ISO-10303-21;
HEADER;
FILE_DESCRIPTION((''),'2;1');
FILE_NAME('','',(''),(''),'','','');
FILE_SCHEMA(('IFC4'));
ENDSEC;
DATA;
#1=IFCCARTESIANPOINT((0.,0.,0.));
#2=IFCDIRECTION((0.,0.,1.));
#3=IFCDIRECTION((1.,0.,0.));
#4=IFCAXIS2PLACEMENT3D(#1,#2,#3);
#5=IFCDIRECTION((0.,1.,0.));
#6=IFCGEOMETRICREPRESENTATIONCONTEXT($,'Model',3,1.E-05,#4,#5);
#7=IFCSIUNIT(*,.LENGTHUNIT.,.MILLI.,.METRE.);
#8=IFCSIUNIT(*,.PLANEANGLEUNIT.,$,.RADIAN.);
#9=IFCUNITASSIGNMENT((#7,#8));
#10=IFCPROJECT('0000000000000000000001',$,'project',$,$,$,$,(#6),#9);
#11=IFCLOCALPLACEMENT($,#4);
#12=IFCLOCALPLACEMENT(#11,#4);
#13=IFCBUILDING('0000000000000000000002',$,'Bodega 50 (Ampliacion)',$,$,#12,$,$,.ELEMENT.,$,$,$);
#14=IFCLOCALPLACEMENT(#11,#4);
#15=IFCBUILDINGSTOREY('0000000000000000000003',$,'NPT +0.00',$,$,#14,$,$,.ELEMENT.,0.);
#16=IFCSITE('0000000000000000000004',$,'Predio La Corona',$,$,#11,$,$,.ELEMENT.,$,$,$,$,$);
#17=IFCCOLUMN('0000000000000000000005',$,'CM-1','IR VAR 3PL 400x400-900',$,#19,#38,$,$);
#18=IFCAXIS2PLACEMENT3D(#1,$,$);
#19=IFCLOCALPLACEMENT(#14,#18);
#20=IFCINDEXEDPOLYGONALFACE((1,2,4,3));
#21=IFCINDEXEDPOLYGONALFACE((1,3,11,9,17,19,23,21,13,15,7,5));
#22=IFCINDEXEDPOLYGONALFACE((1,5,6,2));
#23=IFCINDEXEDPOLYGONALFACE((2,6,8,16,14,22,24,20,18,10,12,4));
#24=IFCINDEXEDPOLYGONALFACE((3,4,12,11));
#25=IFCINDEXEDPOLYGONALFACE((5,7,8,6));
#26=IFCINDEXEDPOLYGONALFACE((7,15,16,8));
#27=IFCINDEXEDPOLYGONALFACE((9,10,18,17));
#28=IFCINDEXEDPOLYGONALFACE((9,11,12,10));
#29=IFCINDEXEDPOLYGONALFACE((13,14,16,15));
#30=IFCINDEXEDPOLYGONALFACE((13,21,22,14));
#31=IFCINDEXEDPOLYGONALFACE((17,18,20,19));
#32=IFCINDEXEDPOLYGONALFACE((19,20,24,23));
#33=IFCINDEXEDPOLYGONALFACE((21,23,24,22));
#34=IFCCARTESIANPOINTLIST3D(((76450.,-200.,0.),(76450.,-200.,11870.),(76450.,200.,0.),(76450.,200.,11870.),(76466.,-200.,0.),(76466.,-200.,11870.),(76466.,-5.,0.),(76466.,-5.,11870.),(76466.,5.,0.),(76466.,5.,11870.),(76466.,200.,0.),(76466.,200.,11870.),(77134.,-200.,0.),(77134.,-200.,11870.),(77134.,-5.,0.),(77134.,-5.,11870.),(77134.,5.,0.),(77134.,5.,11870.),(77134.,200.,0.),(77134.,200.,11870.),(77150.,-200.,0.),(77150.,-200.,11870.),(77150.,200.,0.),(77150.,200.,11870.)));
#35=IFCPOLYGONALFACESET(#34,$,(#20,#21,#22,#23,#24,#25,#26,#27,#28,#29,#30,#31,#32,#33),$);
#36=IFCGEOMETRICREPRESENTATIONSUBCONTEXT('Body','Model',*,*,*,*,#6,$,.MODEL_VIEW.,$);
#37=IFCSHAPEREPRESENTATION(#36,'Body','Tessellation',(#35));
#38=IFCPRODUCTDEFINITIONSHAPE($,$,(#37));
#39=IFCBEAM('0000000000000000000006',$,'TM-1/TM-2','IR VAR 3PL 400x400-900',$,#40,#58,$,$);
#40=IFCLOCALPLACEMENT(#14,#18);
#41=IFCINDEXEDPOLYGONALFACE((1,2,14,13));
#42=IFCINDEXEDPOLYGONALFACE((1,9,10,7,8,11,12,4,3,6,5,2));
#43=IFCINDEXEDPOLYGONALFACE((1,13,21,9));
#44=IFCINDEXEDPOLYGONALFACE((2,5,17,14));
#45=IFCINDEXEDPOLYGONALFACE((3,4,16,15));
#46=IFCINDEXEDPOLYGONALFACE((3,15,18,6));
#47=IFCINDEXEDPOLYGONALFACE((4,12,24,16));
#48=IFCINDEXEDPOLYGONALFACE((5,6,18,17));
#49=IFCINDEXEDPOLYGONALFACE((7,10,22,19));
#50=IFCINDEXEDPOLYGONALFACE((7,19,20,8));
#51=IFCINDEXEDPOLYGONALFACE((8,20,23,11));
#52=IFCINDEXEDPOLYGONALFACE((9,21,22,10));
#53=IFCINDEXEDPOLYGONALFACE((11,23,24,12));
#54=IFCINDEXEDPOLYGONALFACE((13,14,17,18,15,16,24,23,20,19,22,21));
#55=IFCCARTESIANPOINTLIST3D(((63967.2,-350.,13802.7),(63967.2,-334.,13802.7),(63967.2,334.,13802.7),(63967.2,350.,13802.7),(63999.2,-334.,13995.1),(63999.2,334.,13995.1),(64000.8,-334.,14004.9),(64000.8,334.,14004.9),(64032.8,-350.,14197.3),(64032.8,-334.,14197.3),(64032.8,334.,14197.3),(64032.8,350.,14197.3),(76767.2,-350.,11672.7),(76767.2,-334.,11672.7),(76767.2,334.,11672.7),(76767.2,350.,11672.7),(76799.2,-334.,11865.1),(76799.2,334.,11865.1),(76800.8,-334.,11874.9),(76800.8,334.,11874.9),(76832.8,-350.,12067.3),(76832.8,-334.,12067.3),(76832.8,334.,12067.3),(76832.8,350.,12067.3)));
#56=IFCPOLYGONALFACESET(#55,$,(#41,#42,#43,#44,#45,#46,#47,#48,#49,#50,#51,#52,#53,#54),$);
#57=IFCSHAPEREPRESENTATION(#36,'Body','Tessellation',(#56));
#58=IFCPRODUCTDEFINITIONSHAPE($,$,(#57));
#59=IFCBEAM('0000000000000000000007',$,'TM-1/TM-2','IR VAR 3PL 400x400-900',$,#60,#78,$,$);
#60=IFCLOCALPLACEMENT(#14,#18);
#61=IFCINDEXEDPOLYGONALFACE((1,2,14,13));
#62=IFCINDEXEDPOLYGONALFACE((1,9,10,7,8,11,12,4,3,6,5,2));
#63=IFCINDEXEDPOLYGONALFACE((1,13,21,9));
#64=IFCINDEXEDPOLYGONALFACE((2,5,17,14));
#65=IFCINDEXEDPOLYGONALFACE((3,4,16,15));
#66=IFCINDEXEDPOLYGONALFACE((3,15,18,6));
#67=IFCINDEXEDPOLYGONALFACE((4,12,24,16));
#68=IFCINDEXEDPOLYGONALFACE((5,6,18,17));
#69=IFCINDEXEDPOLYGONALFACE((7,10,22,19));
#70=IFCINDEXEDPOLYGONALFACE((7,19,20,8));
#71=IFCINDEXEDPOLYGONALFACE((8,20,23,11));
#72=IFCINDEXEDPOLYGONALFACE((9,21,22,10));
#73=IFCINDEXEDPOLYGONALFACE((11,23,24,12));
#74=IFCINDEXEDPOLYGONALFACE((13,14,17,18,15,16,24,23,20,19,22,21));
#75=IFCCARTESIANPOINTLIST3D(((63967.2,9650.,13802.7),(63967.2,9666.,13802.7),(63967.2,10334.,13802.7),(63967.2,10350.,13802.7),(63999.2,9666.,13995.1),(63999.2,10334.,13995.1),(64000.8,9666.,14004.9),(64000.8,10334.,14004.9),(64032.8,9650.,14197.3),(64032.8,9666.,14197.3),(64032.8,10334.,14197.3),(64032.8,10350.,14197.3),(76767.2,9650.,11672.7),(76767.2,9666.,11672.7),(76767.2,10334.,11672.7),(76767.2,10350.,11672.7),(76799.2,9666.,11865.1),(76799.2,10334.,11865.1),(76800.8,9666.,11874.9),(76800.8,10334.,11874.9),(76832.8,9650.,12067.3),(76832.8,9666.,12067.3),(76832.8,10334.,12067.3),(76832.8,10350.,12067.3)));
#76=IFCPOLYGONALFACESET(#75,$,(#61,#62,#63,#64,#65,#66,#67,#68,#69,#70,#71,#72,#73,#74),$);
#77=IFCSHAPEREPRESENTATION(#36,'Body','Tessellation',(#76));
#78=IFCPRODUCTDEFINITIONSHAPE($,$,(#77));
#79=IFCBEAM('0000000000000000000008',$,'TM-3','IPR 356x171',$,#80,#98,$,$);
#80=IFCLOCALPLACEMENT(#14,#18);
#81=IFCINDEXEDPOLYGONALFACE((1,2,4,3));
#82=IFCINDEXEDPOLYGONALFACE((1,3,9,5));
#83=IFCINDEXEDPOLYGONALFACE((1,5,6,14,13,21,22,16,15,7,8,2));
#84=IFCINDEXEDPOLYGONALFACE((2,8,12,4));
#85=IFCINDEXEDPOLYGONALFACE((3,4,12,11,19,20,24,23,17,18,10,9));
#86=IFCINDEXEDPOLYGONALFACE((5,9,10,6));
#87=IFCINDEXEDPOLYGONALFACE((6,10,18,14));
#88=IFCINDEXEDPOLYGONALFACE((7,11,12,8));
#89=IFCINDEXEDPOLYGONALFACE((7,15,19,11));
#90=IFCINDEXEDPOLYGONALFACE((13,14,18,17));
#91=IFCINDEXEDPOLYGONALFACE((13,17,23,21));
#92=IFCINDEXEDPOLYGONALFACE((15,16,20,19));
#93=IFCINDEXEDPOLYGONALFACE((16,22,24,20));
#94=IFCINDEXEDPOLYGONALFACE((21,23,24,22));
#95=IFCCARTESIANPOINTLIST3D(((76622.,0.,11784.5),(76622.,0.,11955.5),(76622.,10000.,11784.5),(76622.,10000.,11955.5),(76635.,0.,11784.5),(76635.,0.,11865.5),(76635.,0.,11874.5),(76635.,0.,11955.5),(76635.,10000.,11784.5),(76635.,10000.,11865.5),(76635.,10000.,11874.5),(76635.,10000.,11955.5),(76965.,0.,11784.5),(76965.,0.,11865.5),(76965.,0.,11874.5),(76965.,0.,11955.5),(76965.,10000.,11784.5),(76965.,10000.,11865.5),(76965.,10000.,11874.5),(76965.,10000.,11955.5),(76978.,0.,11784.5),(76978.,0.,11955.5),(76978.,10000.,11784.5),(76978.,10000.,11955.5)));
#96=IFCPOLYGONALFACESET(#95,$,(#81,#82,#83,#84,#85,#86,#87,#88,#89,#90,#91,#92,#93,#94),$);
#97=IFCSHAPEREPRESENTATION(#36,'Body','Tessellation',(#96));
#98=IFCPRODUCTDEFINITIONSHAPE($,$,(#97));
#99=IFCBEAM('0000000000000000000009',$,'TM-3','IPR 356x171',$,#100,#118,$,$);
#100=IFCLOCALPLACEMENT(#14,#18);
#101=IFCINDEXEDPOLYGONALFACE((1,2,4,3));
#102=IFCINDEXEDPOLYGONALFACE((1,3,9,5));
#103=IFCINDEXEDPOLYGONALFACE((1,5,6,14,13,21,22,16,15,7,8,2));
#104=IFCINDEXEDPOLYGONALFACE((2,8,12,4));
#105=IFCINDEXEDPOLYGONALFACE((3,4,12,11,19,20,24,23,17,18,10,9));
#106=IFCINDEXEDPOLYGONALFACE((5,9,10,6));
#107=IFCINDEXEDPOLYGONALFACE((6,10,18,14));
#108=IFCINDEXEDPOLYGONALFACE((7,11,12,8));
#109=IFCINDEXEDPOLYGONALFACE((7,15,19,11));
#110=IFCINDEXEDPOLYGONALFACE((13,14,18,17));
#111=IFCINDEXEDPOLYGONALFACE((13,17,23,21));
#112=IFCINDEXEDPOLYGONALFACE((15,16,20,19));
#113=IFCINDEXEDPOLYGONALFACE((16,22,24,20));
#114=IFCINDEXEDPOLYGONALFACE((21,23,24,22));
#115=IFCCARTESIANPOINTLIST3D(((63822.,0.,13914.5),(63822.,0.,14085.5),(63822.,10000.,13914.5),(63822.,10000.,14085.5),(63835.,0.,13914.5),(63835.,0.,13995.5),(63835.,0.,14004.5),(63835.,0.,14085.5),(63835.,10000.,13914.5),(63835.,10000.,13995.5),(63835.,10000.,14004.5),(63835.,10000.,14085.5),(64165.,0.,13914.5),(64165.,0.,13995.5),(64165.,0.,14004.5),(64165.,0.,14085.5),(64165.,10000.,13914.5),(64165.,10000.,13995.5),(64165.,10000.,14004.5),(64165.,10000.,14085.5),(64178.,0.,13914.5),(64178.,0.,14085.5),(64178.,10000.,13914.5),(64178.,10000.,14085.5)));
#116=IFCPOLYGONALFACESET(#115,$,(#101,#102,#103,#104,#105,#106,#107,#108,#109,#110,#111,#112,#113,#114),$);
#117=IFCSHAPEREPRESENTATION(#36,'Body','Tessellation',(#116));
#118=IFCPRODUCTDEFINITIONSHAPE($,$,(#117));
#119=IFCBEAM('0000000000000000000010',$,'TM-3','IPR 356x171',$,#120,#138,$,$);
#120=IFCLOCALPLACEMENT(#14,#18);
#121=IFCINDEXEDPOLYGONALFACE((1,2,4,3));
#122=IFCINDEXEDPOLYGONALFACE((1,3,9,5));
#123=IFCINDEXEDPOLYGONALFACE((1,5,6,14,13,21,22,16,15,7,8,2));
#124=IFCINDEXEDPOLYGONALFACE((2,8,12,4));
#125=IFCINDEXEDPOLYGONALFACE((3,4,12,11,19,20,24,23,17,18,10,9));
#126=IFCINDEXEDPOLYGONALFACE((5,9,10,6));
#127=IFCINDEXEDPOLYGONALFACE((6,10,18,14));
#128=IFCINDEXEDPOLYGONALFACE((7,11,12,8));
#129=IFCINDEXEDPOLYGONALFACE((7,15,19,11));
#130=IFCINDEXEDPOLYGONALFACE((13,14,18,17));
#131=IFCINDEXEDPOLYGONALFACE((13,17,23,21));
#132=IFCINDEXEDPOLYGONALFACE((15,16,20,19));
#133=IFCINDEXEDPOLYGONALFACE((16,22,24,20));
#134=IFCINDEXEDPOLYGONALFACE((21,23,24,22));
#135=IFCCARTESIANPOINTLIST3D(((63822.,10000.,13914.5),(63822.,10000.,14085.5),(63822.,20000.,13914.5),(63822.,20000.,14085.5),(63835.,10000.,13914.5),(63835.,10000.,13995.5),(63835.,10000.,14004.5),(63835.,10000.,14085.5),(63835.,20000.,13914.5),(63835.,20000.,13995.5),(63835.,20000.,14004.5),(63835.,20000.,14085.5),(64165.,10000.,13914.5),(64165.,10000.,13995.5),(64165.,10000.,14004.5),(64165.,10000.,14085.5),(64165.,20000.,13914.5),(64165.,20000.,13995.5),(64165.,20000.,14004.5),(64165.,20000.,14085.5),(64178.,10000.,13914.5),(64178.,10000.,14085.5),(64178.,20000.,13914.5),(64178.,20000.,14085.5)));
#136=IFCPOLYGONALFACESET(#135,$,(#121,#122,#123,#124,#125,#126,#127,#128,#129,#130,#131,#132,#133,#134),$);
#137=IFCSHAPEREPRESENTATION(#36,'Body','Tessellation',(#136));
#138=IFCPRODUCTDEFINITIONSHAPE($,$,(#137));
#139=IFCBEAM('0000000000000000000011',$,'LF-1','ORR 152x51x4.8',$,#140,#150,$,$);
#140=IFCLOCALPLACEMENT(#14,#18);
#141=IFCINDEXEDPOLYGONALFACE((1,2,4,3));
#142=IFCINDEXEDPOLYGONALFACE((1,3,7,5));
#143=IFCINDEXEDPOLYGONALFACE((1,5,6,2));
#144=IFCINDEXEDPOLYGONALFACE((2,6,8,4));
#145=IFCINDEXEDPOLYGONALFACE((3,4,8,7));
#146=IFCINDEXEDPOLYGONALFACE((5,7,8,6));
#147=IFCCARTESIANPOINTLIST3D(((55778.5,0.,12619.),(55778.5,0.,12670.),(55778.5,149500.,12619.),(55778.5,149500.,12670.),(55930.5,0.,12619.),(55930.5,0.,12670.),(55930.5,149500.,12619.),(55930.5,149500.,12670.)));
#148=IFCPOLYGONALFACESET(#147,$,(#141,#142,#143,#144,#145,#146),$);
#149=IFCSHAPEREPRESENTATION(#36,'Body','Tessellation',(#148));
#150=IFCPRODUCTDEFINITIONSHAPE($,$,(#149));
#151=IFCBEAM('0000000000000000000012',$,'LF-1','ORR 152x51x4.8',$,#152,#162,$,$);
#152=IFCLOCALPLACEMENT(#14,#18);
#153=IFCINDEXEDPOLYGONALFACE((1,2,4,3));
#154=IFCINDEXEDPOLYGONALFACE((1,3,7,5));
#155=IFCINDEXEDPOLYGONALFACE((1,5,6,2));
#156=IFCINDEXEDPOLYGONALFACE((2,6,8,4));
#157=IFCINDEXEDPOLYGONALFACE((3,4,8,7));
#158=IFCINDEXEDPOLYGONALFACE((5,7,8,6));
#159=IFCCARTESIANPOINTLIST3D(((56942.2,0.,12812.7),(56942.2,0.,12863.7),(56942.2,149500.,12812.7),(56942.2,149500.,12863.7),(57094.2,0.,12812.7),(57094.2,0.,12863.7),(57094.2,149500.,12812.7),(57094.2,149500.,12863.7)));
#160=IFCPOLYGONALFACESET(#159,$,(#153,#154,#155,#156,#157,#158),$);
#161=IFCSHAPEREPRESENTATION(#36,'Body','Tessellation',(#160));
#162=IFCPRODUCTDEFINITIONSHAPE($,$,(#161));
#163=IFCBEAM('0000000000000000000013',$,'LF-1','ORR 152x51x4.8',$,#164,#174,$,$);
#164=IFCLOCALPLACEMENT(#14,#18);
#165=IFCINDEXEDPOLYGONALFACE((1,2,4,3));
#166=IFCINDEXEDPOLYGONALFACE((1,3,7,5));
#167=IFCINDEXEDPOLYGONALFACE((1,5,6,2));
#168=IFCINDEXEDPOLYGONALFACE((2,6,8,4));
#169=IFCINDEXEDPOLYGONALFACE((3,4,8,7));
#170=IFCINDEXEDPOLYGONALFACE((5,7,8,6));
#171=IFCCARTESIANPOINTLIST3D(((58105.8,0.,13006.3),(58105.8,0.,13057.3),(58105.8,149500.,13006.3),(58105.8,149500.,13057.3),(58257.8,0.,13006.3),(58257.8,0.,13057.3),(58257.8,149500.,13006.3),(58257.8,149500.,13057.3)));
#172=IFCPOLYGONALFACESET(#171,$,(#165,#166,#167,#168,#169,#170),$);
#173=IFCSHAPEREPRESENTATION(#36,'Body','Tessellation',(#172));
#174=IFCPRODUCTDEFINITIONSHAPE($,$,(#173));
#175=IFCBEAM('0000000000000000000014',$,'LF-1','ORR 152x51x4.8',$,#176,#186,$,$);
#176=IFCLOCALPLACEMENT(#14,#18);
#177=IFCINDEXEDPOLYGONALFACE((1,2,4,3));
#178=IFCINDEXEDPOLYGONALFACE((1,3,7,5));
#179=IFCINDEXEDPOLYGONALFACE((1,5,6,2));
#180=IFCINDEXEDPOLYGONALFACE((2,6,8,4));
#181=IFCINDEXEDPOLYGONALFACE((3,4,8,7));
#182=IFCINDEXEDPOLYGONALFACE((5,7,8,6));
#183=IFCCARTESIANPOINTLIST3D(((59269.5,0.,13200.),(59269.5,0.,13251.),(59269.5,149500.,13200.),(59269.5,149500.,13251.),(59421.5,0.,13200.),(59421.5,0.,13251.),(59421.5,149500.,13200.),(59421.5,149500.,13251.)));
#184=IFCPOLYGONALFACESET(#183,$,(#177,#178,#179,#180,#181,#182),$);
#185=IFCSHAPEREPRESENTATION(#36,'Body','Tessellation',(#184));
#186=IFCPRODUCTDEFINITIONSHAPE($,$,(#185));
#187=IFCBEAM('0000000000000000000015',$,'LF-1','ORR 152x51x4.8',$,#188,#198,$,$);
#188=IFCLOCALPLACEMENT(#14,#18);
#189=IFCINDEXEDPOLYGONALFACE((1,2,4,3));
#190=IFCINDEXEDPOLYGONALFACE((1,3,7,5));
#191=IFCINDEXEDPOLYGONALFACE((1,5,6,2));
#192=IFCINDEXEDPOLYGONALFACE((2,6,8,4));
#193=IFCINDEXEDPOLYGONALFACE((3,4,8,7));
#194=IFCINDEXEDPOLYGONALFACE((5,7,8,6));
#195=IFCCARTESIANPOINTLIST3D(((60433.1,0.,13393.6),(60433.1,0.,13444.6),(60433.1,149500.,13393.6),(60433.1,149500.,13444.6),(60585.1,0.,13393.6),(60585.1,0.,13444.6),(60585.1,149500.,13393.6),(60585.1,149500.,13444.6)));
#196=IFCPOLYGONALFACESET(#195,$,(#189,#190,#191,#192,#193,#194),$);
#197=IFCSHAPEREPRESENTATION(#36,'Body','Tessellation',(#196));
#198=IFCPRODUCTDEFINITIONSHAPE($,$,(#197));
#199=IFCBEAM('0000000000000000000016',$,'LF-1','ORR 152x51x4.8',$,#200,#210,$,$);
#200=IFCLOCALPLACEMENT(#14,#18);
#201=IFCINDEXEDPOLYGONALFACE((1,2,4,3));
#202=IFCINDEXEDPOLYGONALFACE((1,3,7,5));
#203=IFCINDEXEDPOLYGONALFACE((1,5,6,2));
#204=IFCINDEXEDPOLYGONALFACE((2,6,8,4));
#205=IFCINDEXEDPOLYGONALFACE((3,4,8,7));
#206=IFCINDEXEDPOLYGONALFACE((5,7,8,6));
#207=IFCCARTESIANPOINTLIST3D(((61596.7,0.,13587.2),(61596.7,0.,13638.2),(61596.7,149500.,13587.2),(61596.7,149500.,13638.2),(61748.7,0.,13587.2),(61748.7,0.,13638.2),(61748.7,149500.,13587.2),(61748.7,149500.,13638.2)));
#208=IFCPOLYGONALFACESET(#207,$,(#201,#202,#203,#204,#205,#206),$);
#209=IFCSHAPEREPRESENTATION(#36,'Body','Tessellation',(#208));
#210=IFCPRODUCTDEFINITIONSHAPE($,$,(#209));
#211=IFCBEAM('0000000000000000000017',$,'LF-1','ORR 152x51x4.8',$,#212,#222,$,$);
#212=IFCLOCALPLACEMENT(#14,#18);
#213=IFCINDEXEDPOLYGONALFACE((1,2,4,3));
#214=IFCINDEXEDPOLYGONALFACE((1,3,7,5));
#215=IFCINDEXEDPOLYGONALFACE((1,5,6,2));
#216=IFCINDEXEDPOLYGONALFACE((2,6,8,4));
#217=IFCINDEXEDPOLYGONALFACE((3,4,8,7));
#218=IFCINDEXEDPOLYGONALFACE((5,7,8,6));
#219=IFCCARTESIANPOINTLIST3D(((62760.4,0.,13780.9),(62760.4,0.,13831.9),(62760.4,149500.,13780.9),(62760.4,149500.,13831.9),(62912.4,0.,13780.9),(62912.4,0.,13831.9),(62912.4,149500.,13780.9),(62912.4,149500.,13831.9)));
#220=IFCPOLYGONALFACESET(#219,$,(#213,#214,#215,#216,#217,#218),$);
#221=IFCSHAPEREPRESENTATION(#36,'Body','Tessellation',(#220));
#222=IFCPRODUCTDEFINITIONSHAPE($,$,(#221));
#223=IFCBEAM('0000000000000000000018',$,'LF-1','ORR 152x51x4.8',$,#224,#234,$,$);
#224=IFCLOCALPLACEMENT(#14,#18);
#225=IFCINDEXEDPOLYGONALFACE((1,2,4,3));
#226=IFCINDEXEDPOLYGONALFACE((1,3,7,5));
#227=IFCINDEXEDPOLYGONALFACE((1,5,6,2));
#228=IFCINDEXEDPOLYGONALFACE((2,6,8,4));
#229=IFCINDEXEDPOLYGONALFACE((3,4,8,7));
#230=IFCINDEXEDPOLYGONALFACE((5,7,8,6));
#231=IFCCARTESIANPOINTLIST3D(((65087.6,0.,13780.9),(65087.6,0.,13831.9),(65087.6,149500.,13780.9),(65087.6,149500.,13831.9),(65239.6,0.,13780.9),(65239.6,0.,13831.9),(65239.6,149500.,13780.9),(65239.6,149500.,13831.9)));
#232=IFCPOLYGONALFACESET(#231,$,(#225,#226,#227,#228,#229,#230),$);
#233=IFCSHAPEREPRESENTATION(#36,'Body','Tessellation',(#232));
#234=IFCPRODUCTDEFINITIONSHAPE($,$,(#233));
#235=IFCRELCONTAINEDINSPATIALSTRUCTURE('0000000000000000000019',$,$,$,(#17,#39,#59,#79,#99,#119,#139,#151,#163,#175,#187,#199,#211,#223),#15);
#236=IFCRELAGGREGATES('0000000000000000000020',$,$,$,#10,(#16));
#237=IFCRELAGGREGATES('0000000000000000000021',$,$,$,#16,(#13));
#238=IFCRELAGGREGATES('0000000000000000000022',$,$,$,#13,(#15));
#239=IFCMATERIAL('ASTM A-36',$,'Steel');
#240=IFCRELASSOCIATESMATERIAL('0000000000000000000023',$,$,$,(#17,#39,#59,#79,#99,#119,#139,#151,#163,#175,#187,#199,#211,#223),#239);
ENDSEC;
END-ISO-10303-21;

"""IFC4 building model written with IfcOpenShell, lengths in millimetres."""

from ifc_helpers import new_model, si_unit, direction, frame, origin_with_axes, origin_2d, place, context, subcontext, project, spatial, rectangle, i_section, extrude, material, element, save


model = new_model("IFC4")

# Units and contexts
model_context = context("Model", 3, precision=1e-05, world=origin_with_axes(), true_north=direction((0.0, 1.0, 0.0)))
body_context = subcontext(model_context, "Body", "Model", "MODEL_VIEW")
ifc_project = project(units=[si_unit("LENGTHUNIT", "METRE", prefix="MILLI"), si_unit("PLANEANGLEUNIT", "RADIAN")], contexts=[model_context])

# Site, building, storey
site_placement = place(None, origin_with_axes())
site = spatial("IfcSite", under=ifc_project, at=site_placement, Name="Predio La Corona", CompositionType="ELEMENT")
building_placement = place(site_placement, origin_with_axes())
building = spatial("IfcBuilding", under=site, at=building_placement, Name="Bodega 50 (Ampliacion)", CompositionType="ELEMENT")
storey_placement = place(site_placement, origin_with_axes())
storey = spatial("IfcBuildingStorey", under=building, at=storey_placement, Name="NPT +0.00", CompositionType="ELEMENT", Elevation=0.0)

# Column
ifc_material = material(Name="ASTM A-36", Category="Steel")
column_placement = place(storey_placement, frame((76800.0, 0.0, 0.0), z_axis=(0.0, 0.0, 1.0), x_axis=(0.0, -1.0, 0.0)))
element("IfcColumn", 1, at=column_placement, inside=storey, material=ifc_material, Name="CM-1", Description="IR VAR 3PL 400x400-900", context=body_context, shape_type="SweptSolid", body=[
    extrude(i_section(OverallWidth=400.0, OverallDepth=700.0, WebThickness=10.0, FlangeThickness=16.0, at=origin_2d()), origin_with_axes(), (0.0, 0.0, 1.0), 11870.0),
])

# Beams
for number, where, z_axis, x_axis, name in (
    (2, (64000.0, 0.0, 14000.0), (0.986436, 0.0, -0.164149), (-0.164149, 0.0, -0.986436), "TM-1/TM-2"),
    (3, (64000.0, 10000.0, 14000.0), (0.986436, 0.0, -0.164149), (-0.164149, 0.0, -0.986436), "TM-1/TM-2"),
):
    element("IfcBeam", number, at=place(storey_placement, frame(where, z_axis=z_axis, x_axis=x_axis)), inside=storey, material=ifc_material, Name=name, Description="IR VAR 3PL 400x400-900", context=body_context, shape_type="SweptSolid", body=[
        extrude(i_section(OverallWidth=400.0, OverallDepth=700.0, WebThickness=10.0, FlangeThickness=16.0, at=origin_2d()), origin_with_axes(), (0.0, 0.0, 1.0), 12976.0),
    ])
for number, where, z_axis, x_axis, name in (
    (4, (76800.0, 0.0, 11870.0), (0.0, 1.0, 0.0), (0.0, 0.0, 1.0), "TM-3"),
    (5, (64000.0, 0.0, 14000.0), (0.0, 1.0, 0.0), (0.0, 0.0, 1.0), "TM-3"),
    (6, (64000.0, 10000.0, 14000.0), (0.0, 1.0, 0.0), (0.0, 0.0, 1.0), "TM-3"),
):
    element("IfcBeam", number, at=place(storey_placement, frame(where, z_axis=z_axis, x_axis=x_axis)), inside=storey, material=ifc_material, Name=name, Description="IPR 356x171", context=body_context, shape_type="SweptSolid", body=[
        extrude(i_section(OverallWidth=171.0, OverallDepth=356.0, WebThickness=9.0, FlangeThickness=13.0, at=origin_2d()), origin_with_axes(), (0.0, 0.0, 1.0), 10000.0),
    ])
for number, where, z_axis, x_axis, name in (
    (7, (55854.5, 0.0, 12644.5), (0.0, 1.0, 0.0), (0.0, 0.0, 1.0), "LF-1"),
    (8, (57018.2, 0.0, 12838.2), (0.0, 1.0, 0.0), (0.0, 0.0, 1.0), "LF-1"),
    (9, (58181.8, 0.0, 13031.8), (0.0, 1.0, 0.0), (0.0, 0.0, 1.0), "LF-1"),
    (10, (59345.5, 0.0, 13225.5), (0.0, 1.0, 0.0), (0.0, 0.0, 1.0), "LF-1"),
    (11, (60509.1, 0.0, 13419.1), (0.0, 1.0, 0.0), (0.0, 0.0, 1.0), "LF-1"),
    (12, (61672.7, 0.0, 13612.7), (0.0, 1.0, 0.0), (0.0, 0.0, 1.0), "LF-1"),
    (13, (62836.4, 0.0, 13806.4), (0.0, 1.0, 0.0), (0.0, 0.0, 1.0), "LF-1"),
    (14, (65163.6, 0.0, 13806.4), (0.0, 1.0, 0.0), (0.0, 0.0, 1.0), "LF-1"),
):
    element("IfcBeam", number, at=place(storey_placement, frame(where, z_axis=z_axis, x_axis=x_axis)), inside=storey, material=ifc_material, Name=name, Description="ORR 152x51x4.8", context=body_context, shape_type="SweptSolid", body=[
        extrude(rectangle(XDim=51.0, YDim=152.0, at=origin_2d()), origin_with_axes(), (0.0, 0.0, 1.0), 149500.0),
    ])

save(model, "model.ifc")
